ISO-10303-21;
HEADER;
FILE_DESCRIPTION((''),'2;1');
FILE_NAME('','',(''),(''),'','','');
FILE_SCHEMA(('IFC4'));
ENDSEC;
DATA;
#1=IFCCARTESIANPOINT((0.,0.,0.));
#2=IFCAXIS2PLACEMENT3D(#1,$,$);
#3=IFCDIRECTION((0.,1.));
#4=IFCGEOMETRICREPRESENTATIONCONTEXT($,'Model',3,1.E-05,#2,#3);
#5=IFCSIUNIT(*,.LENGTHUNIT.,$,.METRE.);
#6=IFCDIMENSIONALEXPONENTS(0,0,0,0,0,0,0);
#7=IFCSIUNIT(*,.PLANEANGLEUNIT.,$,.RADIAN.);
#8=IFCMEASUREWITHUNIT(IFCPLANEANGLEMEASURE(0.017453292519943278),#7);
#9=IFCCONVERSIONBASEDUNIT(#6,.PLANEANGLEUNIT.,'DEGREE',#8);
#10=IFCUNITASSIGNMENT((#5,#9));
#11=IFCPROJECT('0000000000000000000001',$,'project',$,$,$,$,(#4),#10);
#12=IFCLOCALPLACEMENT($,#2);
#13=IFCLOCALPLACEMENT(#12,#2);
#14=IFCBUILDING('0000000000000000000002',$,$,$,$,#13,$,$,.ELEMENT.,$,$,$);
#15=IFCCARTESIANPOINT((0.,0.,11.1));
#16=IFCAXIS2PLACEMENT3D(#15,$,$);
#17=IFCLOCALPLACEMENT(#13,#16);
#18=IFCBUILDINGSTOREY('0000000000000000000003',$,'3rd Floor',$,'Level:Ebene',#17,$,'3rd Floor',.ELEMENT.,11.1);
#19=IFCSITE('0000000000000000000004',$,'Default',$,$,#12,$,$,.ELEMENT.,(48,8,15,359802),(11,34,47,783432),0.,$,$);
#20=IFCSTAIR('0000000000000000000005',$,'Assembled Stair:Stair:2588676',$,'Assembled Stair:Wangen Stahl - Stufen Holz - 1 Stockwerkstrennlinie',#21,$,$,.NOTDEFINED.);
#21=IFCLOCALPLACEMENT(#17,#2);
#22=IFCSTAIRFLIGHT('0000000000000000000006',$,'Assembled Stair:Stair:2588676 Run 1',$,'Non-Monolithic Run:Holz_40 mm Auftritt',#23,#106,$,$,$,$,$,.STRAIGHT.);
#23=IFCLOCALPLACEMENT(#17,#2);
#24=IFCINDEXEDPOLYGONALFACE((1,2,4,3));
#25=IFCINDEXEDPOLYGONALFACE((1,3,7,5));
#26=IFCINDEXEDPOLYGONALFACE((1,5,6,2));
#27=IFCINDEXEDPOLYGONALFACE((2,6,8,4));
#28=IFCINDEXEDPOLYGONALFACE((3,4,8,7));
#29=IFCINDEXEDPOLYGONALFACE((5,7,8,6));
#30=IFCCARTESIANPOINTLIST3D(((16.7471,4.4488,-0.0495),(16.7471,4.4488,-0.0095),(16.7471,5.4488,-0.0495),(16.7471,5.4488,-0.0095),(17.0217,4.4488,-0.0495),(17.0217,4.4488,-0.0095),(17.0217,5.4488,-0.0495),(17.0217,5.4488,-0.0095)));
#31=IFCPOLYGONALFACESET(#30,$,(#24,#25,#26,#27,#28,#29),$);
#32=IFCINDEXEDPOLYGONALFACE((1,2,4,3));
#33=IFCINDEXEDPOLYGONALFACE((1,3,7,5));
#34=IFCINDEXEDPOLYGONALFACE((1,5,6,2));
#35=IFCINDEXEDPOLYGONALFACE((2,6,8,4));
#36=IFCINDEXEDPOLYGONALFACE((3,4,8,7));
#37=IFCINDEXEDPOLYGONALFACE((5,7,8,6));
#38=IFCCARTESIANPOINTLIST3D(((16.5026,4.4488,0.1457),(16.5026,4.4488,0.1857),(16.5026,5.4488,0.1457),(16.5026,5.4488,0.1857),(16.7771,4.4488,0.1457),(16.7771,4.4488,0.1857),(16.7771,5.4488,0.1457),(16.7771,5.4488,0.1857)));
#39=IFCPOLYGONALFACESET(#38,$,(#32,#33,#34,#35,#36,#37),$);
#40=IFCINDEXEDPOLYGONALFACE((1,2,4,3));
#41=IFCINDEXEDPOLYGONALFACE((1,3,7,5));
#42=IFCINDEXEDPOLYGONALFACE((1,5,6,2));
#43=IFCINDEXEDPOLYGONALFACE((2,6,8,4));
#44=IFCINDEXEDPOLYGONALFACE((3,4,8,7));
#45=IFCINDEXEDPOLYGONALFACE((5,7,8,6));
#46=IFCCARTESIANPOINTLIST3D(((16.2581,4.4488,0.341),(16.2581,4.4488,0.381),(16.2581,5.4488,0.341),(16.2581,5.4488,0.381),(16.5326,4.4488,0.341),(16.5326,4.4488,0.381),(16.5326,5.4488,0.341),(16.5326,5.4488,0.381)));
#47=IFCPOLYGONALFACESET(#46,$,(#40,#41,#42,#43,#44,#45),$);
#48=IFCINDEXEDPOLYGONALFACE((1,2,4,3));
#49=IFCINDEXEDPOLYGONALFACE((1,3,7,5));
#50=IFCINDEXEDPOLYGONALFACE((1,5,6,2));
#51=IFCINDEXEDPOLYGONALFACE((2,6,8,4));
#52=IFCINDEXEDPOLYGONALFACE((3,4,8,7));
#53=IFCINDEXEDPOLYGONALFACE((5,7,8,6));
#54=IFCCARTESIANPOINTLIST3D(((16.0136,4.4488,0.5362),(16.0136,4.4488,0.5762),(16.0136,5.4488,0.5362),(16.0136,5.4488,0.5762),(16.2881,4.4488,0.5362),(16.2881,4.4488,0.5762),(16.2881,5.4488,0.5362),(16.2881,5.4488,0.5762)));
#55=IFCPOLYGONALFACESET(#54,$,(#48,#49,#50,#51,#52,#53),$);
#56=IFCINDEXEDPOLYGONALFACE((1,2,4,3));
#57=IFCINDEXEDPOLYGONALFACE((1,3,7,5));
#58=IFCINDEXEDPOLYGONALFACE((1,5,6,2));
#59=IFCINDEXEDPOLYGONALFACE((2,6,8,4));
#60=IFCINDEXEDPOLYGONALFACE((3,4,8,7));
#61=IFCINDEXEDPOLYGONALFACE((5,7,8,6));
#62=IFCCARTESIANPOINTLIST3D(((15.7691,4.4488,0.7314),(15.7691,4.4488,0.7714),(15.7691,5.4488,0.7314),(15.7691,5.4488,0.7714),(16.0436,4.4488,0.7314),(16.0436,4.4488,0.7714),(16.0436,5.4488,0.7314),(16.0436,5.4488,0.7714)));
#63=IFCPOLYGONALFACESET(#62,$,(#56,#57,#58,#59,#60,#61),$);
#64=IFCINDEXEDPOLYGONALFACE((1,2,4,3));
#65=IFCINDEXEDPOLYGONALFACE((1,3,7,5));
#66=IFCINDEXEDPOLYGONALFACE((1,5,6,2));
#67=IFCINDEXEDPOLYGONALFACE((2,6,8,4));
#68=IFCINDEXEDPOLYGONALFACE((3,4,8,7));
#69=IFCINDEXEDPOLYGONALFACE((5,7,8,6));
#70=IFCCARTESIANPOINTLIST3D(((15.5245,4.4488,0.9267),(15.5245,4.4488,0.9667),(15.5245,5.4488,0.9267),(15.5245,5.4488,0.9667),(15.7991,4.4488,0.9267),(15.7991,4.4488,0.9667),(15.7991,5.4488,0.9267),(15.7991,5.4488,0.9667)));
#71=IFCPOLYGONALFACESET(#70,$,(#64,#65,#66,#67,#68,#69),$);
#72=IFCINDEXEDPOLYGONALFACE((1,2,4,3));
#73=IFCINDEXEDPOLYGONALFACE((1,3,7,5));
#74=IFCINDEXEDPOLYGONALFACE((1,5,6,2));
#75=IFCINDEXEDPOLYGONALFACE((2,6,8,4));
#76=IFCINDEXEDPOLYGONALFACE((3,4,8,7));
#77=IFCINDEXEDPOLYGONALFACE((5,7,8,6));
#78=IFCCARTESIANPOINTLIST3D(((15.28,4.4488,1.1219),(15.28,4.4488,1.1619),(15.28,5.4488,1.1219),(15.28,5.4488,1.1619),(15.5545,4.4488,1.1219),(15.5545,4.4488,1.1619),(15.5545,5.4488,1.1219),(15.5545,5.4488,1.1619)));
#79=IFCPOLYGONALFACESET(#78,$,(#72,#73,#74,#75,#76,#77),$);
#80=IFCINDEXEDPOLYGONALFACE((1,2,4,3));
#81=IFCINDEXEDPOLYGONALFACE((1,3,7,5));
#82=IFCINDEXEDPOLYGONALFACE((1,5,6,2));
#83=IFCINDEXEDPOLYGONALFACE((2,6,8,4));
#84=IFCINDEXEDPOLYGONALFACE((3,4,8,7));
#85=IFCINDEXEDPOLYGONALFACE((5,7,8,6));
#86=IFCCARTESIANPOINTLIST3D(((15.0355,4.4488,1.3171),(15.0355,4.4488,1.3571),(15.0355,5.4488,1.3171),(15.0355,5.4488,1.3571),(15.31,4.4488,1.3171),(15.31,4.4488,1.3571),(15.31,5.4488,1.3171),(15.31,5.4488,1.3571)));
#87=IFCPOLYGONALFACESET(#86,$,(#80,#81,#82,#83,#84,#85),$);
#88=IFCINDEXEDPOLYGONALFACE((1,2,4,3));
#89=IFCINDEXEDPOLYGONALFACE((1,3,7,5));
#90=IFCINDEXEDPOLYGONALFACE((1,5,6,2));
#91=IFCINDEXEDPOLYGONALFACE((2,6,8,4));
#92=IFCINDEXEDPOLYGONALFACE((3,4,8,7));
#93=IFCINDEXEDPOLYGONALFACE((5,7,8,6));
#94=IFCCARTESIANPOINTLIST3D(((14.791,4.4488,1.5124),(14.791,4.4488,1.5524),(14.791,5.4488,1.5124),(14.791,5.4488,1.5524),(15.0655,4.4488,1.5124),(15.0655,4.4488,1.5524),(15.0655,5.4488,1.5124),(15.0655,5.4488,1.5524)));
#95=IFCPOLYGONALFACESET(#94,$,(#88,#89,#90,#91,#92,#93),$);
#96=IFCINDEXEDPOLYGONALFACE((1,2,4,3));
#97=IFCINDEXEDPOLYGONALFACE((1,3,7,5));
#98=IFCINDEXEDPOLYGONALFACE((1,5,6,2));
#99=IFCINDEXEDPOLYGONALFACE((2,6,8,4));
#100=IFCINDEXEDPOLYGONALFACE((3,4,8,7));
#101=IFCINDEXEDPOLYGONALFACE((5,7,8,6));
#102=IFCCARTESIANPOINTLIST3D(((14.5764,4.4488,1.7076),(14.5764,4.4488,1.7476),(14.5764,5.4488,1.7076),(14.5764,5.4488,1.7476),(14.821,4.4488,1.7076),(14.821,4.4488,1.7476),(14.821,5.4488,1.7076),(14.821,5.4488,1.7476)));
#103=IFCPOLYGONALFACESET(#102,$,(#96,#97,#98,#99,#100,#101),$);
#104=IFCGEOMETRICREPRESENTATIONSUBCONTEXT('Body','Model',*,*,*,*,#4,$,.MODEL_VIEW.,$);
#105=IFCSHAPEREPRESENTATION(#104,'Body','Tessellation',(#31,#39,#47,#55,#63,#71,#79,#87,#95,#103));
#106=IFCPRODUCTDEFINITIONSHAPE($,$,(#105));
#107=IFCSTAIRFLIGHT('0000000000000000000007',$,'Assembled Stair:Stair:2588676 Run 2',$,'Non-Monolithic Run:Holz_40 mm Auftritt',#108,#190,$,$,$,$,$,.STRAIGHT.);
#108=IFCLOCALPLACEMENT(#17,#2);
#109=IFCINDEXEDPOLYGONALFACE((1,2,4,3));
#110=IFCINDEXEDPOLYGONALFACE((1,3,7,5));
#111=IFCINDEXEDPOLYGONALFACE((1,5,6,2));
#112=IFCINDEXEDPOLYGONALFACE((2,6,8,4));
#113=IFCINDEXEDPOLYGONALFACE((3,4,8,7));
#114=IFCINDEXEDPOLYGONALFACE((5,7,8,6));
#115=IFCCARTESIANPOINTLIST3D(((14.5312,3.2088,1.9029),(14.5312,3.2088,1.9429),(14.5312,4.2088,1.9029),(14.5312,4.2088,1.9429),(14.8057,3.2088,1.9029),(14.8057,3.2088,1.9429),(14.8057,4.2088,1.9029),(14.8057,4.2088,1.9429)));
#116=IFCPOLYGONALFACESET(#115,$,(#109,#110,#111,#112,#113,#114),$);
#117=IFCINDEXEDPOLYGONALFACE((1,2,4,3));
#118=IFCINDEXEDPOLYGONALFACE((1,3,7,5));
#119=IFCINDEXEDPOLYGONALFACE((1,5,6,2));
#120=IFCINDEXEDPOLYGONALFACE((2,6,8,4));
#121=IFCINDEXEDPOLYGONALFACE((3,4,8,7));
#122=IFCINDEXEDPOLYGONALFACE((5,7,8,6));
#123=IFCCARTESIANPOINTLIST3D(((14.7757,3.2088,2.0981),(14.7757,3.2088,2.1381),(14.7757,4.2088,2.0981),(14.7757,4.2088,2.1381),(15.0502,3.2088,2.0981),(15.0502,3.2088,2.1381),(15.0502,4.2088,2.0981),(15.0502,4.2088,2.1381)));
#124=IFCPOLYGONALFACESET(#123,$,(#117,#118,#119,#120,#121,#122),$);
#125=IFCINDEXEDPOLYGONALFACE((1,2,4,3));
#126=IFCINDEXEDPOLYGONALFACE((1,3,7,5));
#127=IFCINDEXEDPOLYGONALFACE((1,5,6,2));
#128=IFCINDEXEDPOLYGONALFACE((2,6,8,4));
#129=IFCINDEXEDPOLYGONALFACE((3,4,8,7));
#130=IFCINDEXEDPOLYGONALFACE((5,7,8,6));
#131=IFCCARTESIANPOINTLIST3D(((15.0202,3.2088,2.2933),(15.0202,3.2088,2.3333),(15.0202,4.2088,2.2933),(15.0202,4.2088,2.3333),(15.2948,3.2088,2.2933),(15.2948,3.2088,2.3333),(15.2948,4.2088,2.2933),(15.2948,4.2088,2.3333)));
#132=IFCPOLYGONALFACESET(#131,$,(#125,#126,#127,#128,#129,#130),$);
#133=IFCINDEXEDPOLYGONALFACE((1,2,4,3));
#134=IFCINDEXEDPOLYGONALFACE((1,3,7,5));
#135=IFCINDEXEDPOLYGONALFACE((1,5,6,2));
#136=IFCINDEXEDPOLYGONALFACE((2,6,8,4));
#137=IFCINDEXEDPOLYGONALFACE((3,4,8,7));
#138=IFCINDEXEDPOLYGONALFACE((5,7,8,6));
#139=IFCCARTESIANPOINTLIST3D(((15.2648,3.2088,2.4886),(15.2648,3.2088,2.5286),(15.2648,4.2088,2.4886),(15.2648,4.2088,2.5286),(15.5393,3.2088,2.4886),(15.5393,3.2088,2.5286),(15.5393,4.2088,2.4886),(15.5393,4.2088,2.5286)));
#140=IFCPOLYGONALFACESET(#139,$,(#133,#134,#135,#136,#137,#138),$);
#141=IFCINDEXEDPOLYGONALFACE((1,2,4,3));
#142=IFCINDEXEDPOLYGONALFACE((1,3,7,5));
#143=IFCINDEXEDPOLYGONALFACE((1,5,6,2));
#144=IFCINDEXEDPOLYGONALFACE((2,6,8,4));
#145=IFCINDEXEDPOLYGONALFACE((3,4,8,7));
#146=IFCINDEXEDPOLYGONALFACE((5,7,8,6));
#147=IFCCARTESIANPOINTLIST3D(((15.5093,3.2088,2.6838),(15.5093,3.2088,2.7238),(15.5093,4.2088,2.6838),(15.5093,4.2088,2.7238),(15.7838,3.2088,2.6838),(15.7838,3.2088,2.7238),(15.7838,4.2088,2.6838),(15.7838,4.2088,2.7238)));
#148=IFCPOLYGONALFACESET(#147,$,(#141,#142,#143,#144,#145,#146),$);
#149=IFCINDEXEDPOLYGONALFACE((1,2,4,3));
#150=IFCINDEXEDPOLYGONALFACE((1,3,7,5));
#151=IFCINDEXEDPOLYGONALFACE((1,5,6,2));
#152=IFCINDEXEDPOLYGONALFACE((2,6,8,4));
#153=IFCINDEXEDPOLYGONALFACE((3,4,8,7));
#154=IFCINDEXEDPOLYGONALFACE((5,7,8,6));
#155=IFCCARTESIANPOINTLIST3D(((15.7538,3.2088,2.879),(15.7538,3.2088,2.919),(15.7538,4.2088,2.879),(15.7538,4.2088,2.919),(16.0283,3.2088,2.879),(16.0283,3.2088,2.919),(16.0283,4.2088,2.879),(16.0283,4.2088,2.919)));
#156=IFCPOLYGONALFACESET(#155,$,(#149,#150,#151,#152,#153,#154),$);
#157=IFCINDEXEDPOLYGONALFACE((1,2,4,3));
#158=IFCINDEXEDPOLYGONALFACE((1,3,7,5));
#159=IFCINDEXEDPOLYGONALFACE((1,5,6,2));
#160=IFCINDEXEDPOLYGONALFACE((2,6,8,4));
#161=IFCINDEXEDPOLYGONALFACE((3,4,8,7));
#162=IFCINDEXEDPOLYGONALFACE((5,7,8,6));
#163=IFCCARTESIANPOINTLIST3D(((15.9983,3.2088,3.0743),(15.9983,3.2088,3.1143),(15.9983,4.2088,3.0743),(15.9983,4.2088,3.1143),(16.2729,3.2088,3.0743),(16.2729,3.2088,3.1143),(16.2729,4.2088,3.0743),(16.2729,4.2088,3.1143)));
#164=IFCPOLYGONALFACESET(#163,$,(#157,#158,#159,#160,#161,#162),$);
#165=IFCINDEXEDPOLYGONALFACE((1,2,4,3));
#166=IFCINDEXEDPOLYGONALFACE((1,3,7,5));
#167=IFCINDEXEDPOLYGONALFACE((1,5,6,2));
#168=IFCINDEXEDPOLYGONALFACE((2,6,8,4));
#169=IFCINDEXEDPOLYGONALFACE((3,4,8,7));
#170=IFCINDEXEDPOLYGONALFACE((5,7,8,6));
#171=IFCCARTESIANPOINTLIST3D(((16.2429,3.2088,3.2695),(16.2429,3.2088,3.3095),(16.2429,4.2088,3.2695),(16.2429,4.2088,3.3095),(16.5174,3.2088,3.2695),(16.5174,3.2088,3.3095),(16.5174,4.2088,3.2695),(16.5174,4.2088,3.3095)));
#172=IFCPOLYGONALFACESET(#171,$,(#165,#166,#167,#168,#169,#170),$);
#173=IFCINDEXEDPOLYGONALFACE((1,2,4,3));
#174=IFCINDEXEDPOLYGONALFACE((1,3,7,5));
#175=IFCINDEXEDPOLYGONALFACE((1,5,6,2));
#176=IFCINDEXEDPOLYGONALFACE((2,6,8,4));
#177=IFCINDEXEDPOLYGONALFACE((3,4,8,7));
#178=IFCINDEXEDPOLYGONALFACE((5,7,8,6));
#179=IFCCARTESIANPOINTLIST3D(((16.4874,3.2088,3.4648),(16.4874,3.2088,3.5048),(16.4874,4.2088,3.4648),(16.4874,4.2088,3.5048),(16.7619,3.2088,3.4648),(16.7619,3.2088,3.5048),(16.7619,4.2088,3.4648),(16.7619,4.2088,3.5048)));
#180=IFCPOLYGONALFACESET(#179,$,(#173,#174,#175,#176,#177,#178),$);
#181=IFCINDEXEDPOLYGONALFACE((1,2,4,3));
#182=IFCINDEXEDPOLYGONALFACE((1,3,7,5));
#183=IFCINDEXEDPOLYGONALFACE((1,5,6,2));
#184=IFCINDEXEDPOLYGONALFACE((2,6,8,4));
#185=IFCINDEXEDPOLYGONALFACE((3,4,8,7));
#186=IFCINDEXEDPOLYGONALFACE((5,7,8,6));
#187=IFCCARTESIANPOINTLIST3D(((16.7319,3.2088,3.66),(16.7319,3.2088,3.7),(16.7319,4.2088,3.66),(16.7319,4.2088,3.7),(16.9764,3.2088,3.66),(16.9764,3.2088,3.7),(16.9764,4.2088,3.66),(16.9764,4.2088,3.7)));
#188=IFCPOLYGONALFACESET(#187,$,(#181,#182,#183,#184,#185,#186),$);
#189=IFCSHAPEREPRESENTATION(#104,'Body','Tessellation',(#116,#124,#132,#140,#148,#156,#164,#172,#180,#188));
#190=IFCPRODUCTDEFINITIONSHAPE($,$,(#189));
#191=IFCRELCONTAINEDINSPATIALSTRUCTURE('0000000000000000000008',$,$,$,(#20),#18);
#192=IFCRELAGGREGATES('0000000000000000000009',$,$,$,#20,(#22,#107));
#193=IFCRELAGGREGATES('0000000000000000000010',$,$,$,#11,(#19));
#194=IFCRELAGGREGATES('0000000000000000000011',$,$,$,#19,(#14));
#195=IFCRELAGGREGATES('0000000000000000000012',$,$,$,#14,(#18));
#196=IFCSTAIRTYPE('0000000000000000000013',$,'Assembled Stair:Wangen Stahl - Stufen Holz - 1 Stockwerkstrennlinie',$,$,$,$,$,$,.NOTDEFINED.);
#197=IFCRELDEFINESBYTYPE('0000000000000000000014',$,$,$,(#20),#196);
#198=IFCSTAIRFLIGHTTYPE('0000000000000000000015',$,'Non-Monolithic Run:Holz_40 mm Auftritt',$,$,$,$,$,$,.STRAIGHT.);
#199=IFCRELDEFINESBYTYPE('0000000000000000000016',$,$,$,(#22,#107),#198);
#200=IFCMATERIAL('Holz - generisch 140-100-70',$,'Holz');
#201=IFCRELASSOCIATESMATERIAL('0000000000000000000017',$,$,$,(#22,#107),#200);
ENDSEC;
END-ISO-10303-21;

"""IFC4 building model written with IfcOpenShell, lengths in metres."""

from ifc_helpers import new_model, entity, si_unit, converted_unit, direction, frame, origin, place, context, subcontext, project, spatial, indexed_curve, outline, extrude, material, type_object, element, aggregate, save


model = new_model("IFC4")

# Units and contexts
model_context = context("Model", 3, precision=1e-05, world=origin(), true_north=direction((0.0, 1.0)))
body_context = subcontext(model_context, "Body", "Model", "MODEL_VIEW")
ifc_project = project(units=[si_unit("LENGTHUNIT", "METRE"), converted_unit("PLANEANGLEUNIT", "DEGREE", entity("IfcPlaneAngleMeasure", 0.017453292519943278), si_unit("PLANEANGLEUNIT", "RADIAN"), dimensions=[0, 0, 0, 0, 0, 0, 0])], contexts=[model_context])

# Site, building, storey
site_placement = place(None, origin())
site = spatial("IfcSite", under=ifc_project, at=site_placement, Name="Default", CompositionType="ELEMENT", RefLatitude=(48, 8, 15, 359802), RefLongitude=(11, 34, 47, 783432), RefElevation=0.0)
building_placement = place(site_placement, origin())
building = spatial("IfcBuilding", under=site, at=building_placement, CompositionType="ELEMENT")
storey_placement = place(building_placement, frame((0.0, 0.0, 11.1)))
storey = spatial("IfcBuildingStorey", under=building, at=storey_placement, Name="3rd Floor", ObjectType="Level:Ebene", LongName="3rd Floor", CompositionType="ELEMENT", Elevation=11.1)

# Stair
stair_type = type_object("IfcStairType", Name="Assembled Stair:Wangen Stahl - Stufen Holz - 1 Stockwerkstrennlinie", PredefinedType="NOTDEFINED")
stair_1_placement = place(storey_placement, origin())
stair_1 = element("IfcStair", 1, at=stair_1_placement, inside=storey, type_object=stair_type, Name="Assembled Stair:Stair:2588676", ObjectType="Assembled Stair:Wangen Stahl - Stufen Holz - 1 Stockwerkstrennlinie", PredefinedType="NOTDEFINED")

# Shared definitions
ifc_material_1 = material(Name="Holz - generisch 140-100-70", Category="Holz")

# Stair flights
stair_flight_type = type_object("IfcStairFlightType", Name="Non-Monolithic Run:Holz_40 mm Auftritt", PredefinedType="STRAIGHT")
stair_flight_1_placement = place(stair_1_placement, origin())
stair_flight_1 = element("IfcStairFlight", 2, at=stair_flight_1_placement, type_object=stair_flight_type, material=ifc_material_1, Name="Assembled Stair:Stair:2588676 Run 1", ObjectType="Non-Monolithic Run:Holz_40 mm Auftritt", PredefinedType="STRAIGHT", context=body_context, shape_type="SweptSolid", body=[
    extrude(outline(indexed_curve([(-0.1373, -0.5), (0.1373, -0.5), (0.1373, 0.5), (-0.1373, 0.5), (-0.1373, -0.5)], self_intersect=False)), frame((16.8844, 4.9488, -0.0495)), (0.0, 0.0, 1.0), 0.04),
    extrude(outline(indexed_curve([(-0.1373, -0.5), (0.1373, -0.5), (0.1373, 0.5), (-0.1373, 0.5), (-0.1373, -0.5)], self_intersect=False)), frame((16.6399, 4.9488, 0.1457)), (0.0, 0.0, 1.0), 0.04),
    extrude(outline(indexed_curve([(-0.1373, -0.5), (0.1373, -0.5), (0.1373, 0.5), (-0.1373, 0.5), (-0.1373, -0.5)], self_intersect=False)), frame((16.3954, 4.9488, 0.341)), (0.0, 0.0, 1.0), 0.04),
    extrude(outline(indexed_curve([(-0.1373, -0.5), (0.1373, -0.5), (0.1373, 0.5), (-0.1373, 0.5), (-0.1373, -0.5)], self_intersect=False)), frame((16.1508, 4.9488, 0.5362)), (0.0, 0.0, 1.0), 0.04),
    extrude(outline(indexed_curve([(-0.1373, -0.5), (0.1373, -0.5), (0.1373, 0.5), (-0.1373, 0.5), (-0.1373, -0.5)], self_intersect=False)), frame((15.9063, 4.9488, 0.7314)), (0.0, 0.0, 1.0), 0.04),
    extrude(outline(indexed_curve([(-0.1373, -0.5), (0.1373, -0.5), (0.1373, 0.5), (-0.1373, 0.5), (-0.1373, -0.5)], self_intersect=False)), frame((15.6618, 4.9488, 0.9267)), (0.0, 0.0, 1.0), 0.04),
    extrude(outline(indexed_curve([(-0.1373, -0.5), (0.1373, -0.5), (0.1373, 0.5), (-0.1373, 0.5), (-0.1373, -0.5)], self_intersect=False)), frame((15.4173, 4.9488, 1.1219)), (0.0, 0.0, 1.0), 0.04),
    extrude(outline(indexed_curve([(-0.1373, -0.5), (0.1373, -0.5), (0.1373, 0.5), (-0.1373, 0.5), (-0.1373, -0.5)], self_intersect=False)), frame((15.1727, 4.9488, 1.3171)), (0.0, 0.0, 1.0), 0.04),
    extrude(outline(indexed_curve([(-0.1373, -0.5), (0.1373, -0.5), (0.1373, 0.5), (-0.1373, 0.5), (-0.1373, -0.5)], self_intersect=False)), frame((14.9282, 4.9488, 1.5124)), (0.0, 0.0, 1.0), 0.04),
    extrude(outline(indexed_curve([(-0.1223, -0.5), (0.1223, -0.5), (0.1223, 0.5), (-0.1223, 0.5), (-0.1223, -0.5)], self_intersect=False)), frame((14.6987, 4.9488, 1.7076)), (0.0, 0.0, 1.0), 0.04),
])
stair_flight_2_placement = place(stair_1_placement, origin())
stair_flight_2 = element("IfcStairFlight", 3, at=stair_flight_2_placement, type_object=stair_flight_type, material=ifc_material_1, Name="Assembled Stair:Stair:2588676 Run 2", ObjectType="Non-Monolithic Run:Holz_40 mm Auftritt", PredefinedType="STRAIGHT", context=body_context, shape_type="SweptSolid", body=[
    extrude(outline(indexed_curve([(-0.1373, -0.5), (0.1373, -0.5), (0.1373, 0.5), (-0.1373, 0.5), (-0.1373, -0.5)], self_intersect=False)), frame((14.6685, 3.7088, 1.9029), z_axis=(0.0, 0.0, 1.0), x_axis=(-1.0, 0.0, 0.0)), (0.0, 0.0, 1.0), 0.04),
    extrude(outline(indexed_curve([(-0.1373, -0.5), (0.1373, -0.5), (0.1373, 0.5), (-0.1373, 0.5), (-0.1373, -0.5)], self_intersect=False)), frame((14.913, 3.7088, 2.0981), z_axis=(0.0, 0.0, 1.0), x_axis=(-1.0, 0.0, 0.0)), (0.0, 0.0, 1.0), 0.04),
    extrude(outline(indexed_curve([(-0.1373, -0.5), (0.1373, -0.5), (0.1373, 0.5), (-0.1373, 0.5), (-0.1373, -0.5)], self_intersect=False)), frame((15.1575, 3.7088, 2.2933), z_axis=(0.0, 0.0, 1.0), x_axis=(-1.0, 0.0, 0.0)), (0.0, 0.0, 1.0), 0.04),
    extrude(outline(indexed_curve([(-0.1373, -0.5), (0.1373, -0.5), (0.1373, 0.5), (-0.1373, 0.5), (-0.1373, -0.5)], self_intersect=False)), frame((15.402, 3.7088, 2.4886), z_axis=(0.0, 0.0, 1.0), x_axis=(-1.0, 0.0, 0.0)), (0.0, 0.0, 1.0), 0.04),
    extrude(outline(indexed_curve([(-0.1373, -0.5), (0.1373, -0.5), (0.1373, 0.5), (-0.1373, 0.5), (-0.1373, -0.5)], self_intersect=False)), frame((15.6466, 3.7088, 2.6838), z_axis=(0.0, 0.0, 1.0), x_axis=(-1.0, 0.0, 0.0)), (0.0, 0.0, 1.0), 0.04),
    extrude(outline(indexed_curve([(-0.1373, -0.5), (0.1373, -0.5), (0.1373, 0.5), (-0.1373, 0.5), (-0.1373, -0.5)], self_intersect=False)), frame((15.8911, 3.7088, 2.879), z_axis=(0.0, 0.0, 1.0), x_axis=(-1.0, 0.0, 0.0)), (0.0, 0.0, 1.0), 0.04),
    extrude(outline(indexed_curve([(-0.1373, -0.5), (0.1373, -0.5), (0.1373, 0.5), (-0.1373, 0.5), (-0.1373, -0.5)], self_intersect=False)), frame((16.1356, 3.7088, 3.0743), z_axis=(0.0, 0.0, 1.0), x_axis=(-1.0, 0.0, 0.0)), (0.0, 0.0, 1.0), 0.04),
    extrude(outline(indexed_curve([(-0.1373, -0.5), (0.1373, -0.5), (0.1373, 0.5), (-0.1373, 0.5), (-0.1373, -0.5)], self_intersect=False)), frame((16.3801, 3.7088, 3.2695), z_axis=(0.0, 0.0, 1.0), x_axis=(-1.0, 0.0, 0.0)), (0.0, 0.0, 1.0), 0.04),
    extrude(outline(indexed_curve([(-0.1373, -0.5), (0.1373, -0.5), (0.1373, 0.5), (-0.1373, 0.5), (-0.1373, -0.5)], self_intersect=False)), frame((16.6246, 3.7088, 3.4648), z_axis=(0.0, 0.0, 1.0), x_axis=(-1.0, 0.0, 0.0)), (0.0, 0.0, 1.0), 0.04),
    extrude(outline(indexed_curve([(-0.1223, -0.5), (0.1223, -0.5), (0.1223, 0.5), (-0.1223, 0.5), (-0.1223, -0.5)], self_intersect=False)), frame((16.8542, 3.7088, 3.66), z_axis=(0.0, 0.0, 1.0), x_axis=(-1.0, 0.0, 0.0)), (0.0, 0.0, 1.0), 0.04),
])
aggregate(stair_1, [stair_flight_1, stair_flight_2])

save(model, "model.ifc")
